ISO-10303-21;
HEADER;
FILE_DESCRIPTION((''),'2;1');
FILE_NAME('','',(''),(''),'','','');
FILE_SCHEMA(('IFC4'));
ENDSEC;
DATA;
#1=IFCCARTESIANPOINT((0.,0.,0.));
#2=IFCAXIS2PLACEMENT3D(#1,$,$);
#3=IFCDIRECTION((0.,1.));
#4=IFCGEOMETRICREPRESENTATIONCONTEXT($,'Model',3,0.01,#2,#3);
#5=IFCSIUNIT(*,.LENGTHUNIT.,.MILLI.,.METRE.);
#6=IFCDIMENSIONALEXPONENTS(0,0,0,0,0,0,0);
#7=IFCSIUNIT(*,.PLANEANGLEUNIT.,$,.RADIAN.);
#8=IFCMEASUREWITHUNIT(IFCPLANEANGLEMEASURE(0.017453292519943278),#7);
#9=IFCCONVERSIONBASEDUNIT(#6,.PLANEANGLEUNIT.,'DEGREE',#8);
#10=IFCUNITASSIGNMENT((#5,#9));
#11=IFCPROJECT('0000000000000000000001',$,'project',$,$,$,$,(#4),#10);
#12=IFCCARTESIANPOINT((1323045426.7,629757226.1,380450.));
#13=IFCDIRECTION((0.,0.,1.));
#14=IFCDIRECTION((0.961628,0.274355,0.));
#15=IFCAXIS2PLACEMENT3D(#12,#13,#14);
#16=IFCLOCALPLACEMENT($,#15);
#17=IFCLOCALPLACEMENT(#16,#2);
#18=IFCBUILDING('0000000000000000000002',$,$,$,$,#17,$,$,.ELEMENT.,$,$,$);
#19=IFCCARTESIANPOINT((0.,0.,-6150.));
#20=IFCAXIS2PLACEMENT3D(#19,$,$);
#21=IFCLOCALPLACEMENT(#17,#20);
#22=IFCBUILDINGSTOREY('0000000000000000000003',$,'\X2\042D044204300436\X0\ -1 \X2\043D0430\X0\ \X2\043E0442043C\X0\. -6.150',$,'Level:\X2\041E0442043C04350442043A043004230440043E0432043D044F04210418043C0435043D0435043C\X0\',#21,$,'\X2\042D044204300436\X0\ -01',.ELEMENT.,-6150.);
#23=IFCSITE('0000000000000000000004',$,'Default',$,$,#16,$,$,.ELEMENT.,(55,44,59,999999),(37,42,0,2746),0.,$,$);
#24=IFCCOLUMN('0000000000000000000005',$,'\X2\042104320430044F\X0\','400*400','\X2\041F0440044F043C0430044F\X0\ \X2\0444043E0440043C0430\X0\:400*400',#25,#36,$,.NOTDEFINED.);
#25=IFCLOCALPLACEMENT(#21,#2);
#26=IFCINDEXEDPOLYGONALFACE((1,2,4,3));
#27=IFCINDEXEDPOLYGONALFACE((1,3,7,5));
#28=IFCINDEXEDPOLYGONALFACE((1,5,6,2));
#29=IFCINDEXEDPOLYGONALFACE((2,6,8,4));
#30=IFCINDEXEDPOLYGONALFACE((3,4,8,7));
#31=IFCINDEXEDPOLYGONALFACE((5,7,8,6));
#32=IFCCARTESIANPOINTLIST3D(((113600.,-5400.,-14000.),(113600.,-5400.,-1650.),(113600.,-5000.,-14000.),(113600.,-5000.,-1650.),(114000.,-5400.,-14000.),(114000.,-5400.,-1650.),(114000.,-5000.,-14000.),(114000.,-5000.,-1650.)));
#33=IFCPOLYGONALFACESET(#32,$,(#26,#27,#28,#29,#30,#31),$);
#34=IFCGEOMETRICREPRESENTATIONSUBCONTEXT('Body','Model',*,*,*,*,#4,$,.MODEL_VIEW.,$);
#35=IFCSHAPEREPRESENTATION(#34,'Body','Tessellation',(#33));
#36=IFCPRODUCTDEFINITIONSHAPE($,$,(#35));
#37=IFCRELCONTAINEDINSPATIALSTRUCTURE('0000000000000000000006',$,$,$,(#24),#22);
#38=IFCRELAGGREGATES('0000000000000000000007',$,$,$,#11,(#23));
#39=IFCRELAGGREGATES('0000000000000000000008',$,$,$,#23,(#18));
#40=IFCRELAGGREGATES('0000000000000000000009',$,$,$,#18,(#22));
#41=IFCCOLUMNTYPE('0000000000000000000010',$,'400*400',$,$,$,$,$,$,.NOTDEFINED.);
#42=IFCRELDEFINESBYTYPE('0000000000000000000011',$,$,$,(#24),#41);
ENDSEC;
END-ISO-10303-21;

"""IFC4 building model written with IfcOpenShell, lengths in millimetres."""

from ifc_helpers import new_model, entity, si_unit, converted_unit, direction, frame, origin, place, context, subcontext, project, spatial, indexed_curve, outline, extrude, type_object, element, save


model = new_model("IFC4")

# Units and contexts
model_context = context("Model", 3, precision=0.01, world=origin(), true_north=direction((0.0, 1.0)))
body_context = subcontext(model_context, "Body", "Model", "MODEL_VIEW")
ifc_project = project(units=[si_unit("LENGTHUNIT", "METRE", prefix="MILLI"), converted_unit("PLANEANGLEUNIT", "DEGREE", entity("IfcPlaneAngleMeasure", 0.017453292519943278), si_unit("PLANEANGLEUNIT", "RADIAN"), dimensions=[0, 0, 0, 0, 0, 0, 0])], contexts=[model_context])

# Site, building, storey
site_placement = place(None, frame((1323045426.7, 629757226.1, 380450.0), z_axis=(0.0, 0.0, 1.0), x_axis=(0.961628, 0.274355, 0.0)))
site = spatial("IfcSite", under=ifc_project, at=site_placement, Name="Default", CompositionType="ELEMENT", RefLatitude=(55, 44, 59, 999999), RefLongitude=(37, 42, 0, 2746), RefElevation=0.0)
building_placement = place(site_placement, origin())
building = spatial("IfcBuilding", under=site, at=building_placement, CompositionType="ELEMENT")
storey_placement = place(building_placement, frame((0.0, 0.0, -6150.0)))
storey = spatial("IfcBuildingStorey", under=building, at=storey_placement, Name="Этаж -1 на отм. -6.150", ObjectType="Level:ОтметкаУровняСИменем", LongName="Этаж -01", CompositionType="ELEMENT", Elevation=-6150.0)

# Column
column_type = type_object("IfcColumnType", Name="400*400", PredefinedType="NOTDEFINED")
column_1_placement = place(storey_placement, origin())
element("IfcColumn", 1, at=column_1_placement, inside=storey, type_object=column_type, Name="Свая", Description="400*400", ObjectType="Прямая форма:400*400", PredefinedType="NOTDEFINED", context=body_context, shape_type="SweptSolid", body=[
    extrude(outline(indexed_curve([(-200.0, -200.0), (200.0, -200.0), (200.0, 200.0), (-200.0, 200.0), (-200.0, -200.0)], self_intersect=False)), frame((113800.0, -5200.0, -14000.0), z_axis=(0.0, 0.0, 1.0), x_axis=(0.0, 1.0, 0.0)), (0.0, 0.0, 1.0), 12350.0),
])

save(model, "model.ifc")
